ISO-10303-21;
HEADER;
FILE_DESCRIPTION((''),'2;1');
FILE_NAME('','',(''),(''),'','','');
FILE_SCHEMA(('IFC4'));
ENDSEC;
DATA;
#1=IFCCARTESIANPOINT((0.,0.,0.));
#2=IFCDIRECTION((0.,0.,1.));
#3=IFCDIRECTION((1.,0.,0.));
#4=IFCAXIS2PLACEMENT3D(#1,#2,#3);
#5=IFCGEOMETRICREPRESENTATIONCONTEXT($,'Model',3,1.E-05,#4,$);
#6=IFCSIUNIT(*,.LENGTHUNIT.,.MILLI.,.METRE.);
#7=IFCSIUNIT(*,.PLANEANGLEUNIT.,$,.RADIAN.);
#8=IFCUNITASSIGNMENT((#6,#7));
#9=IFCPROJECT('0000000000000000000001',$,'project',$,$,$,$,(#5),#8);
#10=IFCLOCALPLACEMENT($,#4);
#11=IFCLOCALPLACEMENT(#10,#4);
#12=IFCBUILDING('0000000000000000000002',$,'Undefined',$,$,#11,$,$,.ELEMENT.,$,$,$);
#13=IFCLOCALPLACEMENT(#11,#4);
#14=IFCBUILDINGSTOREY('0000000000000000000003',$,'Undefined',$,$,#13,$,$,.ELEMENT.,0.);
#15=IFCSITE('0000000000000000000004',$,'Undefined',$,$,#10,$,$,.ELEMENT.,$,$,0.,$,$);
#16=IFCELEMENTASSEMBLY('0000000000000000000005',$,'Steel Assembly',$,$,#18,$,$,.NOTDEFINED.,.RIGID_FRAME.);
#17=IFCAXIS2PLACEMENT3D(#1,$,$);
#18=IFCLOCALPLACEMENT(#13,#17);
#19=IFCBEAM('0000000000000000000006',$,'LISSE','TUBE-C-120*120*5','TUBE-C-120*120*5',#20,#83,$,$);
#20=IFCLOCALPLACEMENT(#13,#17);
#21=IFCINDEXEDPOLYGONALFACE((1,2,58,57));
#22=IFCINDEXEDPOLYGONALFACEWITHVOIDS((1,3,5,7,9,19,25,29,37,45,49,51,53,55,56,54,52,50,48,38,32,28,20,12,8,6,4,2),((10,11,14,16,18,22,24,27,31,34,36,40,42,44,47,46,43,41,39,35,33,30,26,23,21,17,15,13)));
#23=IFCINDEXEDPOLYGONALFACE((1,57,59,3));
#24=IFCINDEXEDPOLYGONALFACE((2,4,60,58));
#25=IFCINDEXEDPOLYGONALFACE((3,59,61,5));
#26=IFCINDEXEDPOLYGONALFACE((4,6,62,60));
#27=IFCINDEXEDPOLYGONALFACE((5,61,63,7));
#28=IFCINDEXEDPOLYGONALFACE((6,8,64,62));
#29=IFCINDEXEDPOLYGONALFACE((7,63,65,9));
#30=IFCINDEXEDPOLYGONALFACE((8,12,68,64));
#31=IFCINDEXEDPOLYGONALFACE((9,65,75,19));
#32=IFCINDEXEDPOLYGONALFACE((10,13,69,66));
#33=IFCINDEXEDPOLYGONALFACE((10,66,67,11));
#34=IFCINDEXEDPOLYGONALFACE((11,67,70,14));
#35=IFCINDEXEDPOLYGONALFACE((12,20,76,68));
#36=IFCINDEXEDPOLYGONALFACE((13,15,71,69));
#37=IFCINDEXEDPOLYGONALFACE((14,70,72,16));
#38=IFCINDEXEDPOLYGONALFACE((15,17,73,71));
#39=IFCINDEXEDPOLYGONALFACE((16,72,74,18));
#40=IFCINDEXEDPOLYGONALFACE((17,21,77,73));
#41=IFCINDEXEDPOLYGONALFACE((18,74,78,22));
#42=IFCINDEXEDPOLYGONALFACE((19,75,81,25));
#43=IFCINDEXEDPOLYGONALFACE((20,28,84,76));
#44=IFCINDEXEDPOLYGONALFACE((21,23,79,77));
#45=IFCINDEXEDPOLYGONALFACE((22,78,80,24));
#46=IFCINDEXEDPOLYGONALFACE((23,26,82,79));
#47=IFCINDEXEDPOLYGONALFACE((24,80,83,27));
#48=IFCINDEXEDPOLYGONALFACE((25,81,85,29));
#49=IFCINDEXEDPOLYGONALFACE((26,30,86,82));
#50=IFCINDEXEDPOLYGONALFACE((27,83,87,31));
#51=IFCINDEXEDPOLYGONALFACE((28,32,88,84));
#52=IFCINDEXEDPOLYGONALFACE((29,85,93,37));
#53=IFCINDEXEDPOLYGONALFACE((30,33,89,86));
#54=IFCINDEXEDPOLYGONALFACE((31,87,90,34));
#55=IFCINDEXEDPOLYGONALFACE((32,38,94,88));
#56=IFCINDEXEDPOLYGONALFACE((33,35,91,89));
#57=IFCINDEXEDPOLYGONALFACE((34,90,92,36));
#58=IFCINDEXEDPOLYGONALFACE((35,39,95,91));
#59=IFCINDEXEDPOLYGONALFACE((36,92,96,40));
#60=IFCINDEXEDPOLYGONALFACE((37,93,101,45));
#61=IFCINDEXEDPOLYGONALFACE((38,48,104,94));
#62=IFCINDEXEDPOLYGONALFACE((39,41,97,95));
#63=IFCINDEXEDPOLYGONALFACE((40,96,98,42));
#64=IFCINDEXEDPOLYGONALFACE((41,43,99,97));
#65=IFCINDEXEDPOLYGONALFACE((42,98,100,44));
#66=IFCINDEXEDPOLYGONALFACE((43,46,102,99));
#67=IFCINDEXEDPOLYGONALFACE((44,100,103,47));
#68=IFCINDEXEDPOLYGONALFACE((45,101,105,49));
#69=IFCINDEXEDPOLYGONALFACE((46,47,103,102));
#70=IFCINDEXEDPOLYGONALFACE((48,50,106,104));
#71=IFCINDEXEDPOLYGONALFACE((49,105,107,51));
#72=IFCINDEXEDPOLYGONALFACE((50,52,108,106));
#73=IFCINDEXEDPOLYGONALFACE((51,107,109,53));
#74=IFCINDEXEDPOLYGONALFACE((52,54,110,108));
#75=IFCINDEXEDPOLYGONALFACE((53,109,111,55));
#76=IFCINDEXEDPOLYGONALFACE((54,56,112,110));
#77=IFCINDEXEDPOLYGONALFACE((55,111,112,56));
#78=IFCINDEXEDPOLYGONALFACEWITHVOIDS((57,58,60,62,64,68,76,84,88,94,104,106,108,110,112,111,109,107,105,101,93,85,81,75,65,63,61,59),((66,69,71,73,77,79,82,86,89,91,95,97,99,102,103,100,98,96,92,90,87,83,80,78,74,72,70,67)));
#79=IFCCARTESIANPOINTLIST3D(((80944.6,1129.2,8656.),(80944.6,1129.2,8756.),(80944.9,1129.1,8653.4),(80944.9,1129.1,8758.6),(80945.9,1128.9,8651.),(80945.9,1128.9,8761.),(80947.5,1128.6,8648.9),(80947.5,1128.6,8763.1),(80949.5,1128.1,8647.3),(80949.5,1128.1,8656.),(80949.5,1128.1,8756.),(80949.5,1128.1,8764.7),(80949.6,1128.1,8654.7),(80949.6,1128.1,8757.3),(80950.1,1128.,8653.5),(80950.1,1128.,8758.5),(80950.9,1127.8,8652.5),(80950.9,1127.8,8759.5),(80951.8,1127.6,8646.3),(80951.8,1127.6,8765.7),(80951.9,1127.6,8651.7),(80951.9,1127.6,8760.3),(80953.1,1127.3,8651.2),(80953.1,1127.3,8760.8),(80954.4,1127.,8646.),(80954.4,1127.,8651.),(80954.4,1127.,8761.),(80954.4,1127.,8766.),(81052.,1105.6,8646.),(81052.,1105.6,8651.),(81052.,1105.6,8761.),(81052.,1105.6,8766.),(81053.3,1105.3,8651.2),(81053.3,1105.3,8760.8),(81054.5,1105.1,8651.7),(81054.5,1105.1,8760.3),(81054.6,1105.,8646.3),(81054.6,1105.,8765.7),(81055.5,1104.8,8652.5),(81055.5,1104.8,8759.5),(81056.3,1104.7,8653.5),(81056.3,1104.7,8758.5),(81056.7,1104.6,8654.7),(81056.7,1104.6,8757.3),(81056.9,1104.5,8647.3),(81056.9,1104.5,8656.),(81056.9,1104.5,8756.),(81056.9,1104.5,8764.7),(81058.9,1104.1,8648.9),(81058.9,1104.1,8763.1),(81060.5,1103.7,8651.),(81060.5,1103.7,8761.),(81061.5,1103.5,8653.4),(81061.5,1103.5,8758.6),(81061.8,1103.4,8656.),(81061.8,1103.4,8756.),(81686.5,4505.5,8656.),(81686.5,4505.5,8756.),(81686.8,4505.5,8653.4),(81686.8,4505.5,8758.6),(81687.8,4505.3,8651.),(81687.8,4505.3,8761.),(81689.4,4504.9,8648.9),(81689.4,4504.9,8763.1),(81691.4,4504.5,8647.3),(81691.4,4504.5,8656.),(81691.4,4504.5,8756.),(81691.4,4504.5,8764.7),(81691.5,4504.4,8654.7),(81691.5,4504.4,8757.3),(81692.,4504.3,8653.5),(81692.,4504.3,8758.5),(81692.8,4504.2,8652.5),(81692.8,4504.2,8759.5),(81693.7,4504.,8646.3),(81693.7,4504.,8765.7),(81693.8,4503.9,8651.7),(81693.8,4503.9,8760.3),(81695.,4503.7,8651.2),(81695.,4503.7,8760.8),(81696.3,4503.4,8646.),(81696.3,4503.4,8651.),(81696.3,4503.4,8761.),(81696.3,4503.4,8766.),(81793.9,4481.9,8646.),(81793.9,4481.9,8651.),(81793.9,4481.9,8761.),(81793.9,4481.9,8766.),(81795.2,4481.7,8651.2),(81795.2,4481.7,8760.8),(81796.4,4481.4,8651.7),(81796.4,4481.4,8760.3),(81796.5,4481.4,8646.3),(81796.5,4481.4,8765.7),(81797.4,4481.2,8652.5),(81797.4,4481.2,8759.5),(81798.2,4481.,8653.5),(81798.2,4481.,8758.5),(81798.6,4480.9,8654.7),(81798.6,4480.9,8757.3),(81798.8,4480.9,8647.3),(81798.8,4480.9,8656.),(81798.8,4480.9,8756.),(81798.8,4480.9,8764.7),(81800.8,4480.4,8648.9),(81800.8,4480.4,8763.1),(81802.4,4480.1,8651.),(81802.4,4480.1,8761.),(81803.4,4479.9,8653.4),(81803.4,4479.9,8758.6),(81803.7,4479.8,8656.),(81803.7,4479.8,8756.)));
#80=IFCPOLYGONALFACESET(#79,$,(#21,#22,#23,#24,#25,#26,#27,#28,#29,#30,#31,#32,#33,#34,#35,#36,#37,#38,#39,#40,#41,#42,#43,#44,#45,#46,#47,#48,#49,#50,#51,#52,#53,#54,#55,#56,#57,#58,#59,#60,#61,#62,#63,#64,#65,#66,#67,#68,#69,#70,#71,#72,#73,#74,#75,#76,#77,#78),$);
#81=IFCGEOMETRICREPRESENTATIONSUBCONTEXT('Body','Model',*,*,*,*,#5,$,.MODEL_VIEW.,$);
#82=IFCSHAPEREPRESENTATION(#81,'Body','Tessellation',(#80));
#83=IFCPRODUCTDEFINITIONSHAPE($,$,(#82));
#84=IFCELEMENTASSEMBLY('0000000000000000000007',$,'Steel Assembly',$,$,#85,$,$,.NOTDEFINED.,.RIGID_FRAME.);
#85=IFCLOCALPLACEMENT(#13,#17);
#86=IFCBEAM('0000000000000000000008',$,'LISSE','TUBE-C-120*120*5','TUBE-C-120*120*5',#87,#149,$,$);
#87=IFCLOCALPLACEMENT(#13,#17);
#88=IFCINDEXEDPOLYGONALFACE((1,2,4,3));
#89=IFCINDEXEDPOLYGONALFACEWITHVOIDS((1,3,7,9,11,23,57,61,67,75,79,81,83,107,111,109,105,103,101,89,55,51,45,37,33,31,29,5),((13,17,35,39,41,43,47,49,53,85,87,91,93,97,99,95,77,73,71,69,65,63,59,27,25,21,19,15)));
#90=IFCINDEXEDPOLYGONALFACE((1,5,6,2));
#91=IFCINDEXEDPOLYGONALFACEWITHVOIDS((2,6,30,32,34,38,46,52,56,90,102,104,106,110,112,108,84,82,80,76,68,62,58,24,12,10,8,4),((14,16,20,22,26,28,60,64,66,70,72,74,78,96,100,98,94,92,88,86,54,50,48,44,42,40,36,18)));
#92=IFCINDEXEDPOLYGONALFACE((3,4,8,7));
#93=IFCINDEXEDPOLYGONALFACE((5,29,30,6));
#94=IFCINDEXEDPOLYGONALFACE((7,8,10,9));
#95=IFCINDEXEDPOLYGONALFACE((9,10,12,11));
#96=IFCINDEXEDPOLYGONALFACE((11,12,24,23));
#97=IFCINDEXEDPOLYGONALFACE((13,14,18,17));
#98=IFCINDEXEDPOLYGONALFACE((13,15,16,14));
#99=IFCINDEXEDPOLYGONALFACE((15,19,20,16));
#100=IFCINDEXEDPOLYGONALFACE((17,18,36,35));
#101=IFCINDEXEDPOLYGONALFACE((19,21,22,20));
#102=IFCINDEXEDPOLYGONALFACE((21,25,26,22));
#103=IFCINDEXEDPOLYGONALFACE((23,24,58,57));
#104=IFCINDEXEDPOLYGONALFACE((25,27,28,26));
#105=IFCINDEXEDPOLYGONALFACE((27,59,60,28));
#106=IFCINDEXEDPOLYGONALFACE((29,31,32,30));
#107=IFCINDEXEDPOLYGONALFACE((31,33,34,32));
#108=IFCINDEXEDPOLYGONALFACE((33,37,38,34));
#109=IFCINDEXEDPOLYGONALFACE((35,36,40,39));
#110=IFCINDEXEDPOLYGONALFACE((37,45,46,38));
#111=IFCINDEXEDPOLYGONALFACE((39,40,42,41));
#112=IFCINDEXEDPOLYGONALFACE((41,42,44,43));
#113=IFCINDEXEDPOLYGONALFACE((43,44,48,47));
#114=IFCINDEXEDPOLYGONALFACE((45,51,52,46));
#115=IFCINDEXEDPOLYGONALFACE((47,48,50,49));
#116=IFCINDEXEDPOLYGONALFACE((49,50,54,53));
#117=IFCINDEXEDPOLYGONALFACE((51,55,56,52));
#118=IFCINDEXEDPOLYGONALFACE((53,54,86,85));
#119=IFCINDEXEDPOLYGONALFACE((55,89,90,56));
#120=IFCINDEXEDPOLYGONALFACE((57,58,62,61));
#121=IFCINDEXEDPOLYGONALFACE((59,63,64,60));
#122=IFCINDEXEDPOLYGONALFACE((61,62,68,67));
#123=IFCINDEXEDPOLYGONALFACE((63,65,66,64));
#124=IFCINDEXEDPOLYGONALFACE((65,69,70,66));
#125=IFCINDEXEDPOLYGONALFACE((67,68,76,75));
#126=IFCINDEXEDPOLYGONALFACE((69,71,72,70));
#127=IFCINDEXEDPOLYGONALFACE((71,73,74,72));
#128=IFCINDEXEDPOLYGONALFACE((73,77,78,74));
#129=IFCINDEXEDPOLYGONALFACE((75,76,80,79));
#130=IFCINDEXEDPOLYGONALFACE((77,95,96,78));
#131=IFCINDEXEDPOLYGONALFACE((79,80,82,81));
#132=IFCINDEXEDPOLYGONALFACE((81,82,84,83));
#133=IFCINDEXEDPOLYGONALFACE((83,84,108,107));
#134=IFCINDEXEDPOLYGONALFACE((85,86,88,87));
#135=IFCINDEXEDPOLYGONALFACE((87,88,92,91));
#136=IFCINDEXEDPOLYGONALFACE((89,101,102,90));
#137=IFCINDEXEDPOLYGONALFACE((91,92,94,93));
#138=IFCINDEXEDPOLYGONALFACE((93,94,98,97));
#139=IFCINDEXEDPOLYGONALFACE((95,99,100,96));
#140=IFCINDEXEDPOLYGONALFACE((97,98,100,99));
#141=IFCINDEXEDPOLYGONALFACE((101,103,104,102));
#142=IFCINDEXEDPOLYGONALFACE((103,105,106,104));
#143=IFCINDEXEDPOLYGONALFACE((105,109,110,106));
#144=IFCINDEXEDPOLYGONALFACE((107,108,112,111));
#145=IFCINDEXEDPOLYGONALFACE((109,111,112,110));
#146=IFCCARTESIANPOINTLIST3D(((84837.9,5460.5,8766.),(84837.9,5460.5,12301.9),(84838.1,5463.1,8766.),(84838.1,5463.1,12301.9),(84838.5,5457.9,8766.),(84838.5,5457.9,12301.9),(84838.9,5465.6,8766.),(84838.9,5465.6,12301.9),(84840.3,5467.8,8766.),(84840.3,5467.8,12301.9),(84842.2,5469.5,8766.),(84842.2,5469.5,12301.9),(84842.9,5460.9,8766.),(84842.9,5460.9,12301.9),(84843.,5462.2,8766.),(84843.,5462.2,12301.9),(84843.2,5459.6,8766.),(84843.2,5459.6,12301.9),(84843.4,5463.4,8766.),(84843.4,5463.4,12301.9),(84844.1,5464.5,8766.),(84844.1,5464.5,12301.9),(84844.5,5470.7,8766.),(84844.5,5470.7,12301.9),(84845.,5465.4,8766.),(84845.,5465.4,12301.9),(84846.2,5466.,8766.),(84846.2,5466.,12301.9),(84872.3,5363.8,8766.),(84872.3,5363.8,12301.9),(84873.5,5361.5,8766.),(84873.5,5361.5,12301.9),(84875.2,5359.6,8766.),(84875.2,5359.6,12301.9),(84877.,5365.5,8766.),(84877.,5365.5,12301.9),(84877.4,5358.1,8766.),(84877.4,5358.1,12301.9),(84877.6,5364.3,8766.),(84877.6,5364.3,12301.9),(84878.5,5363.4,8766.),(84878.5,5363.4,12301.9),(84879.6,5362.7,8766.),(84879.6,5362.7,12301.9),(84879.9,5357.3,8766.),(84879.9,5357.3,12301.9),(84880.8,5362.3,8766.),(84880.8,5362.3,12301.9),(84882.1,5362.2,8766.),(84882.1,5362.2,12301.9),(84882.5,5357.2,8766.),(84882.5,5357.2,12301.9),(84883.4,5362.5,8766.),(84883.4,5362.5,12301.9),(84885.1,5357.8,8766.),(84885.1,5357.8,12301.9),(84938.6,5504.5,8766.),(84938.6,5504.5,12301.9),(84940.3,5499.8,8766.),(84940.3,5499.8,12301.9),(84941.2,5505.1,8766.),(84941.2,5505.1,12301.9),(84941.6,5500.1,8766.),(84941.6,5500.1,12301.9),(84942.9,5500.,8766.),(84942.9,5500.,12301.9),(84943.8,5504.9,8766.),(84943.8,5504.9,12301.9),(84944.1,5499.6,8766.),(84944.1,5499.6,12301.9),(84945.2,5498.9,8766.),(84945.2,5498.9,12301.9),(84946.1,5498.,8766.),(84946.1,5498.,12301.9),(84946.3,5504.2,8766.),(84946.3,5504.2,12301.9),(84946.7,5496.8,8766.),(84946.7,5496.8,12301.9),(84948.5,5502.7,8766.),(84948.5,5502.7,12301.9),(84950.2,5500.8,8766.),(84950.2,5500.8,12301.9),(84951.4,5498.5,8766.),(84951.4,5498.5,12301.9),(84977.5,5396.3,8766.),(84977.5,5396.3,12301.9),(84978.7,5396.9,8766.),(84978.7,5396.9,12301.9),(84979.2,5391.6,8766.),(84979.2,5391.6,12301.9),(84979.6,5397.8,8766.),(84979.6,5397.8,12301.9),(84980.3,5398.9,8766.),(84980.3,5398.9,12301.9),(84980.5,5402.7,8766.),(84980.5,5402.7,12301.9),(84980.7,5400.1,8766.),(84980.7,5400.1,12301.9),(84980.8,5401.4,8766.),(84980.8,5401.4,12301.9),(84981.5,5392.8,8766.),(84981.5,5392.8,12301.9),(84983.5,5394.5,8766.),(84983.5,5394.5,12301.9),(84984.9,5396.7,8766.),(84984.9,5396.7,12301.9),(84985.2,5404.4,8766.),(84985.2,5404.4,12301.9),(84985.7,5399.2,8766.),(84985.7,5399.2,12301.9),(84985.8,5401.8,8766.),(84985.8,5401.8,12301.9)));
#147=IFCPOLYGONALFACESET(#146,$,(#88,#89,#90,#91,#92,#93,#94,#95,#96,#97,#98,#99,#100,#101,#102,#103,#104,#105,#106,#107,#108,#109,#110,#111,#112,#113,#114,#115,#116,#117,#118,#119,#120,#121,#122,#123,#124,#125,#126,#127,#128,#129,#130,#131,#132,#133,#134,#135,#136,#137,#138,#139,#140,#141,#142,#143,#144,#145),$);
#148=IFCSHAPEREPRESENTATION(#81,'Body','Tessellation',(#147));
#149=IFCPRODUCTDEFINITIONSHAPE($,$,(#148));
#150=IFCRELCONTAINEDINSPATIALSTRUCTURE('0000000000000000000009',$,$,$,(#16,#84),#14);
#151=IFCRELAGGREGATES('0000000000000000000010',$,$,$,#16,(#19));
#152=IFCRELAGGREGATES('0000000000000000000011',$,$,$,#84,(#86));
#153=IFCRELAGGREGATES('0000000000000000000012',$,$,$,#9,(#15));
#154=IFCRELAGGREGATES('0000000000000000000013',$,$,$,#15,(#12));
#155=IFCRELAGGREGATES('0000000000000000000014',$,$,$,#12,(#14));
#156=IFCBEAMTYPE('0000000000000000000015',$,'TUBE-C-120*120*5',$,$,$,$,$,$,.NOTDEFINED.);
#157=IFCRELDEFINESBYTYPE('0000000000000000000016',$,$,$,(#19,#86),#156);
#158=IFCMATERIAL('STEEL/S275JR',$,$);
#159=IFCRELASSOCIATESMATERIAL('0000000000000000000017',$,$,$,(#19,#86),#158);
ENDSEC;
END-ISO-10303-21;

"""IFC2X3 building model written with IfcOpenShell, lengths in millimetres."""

from ifc_helpers import new_model, si_unit, frame, origin_with_axes, origin_2d_with_axis, place, context, subcontext, project, spatial, hollow_rectangle, extrude, material, type_object, element, aggregate, save


model = new_model("IFC2X3")

# Units and contexts
model_context = context("Model", 3, precision=1e-05, world=origin_with_axes())
body_context = subcontext(model_context, "Body", "Model", "MODEL_VIEW")
ifc_project = project(units=[si_unit("LENGTHUNIT", "METRE", prefix="MILLI"), si_unit("PLANEANGLEUNIT", "RADIAN")], contexts=[model_context])

# Site, building, storey
site_placement = place(None, origin_with_axes())
site = spatial("IfcSite", under=ifc_project, at=site_placement, Name="Undefined", CompositionType="ELEMENT", RefElevation=0.0)
building_placement = place(site_placement, origin_with_axes())
building = spatial("IfcBuilding", under=site, at=building_placement, Name="Undefined", CompositionType="ELEMENT")
storey_placement = place(building_placement, origin_with_axes())
storey = spatial("IfcBuildingStorey", under=building, at=storey_placement, Name="Undefined", CompositionType="ELEMENT", Elevation=0.0)

# Element assemblies, beams
ifc_material_1 = material(Name="STEEL/S275JR")
beam_type_1 = type_object("IfcBeamType", Name="TUBE-C-120*120*5", PredefinedType="NOTDEFINED")
assembly_1_placement = place(storey_placement, origin_with_axes())
assembly_1 = element("IfcElementAssembly", 1, at=assembly_1_placement, inside=storey, Name="Steel Assembly", AssemblyPlace="NOTDEFINED", PredefinedType="RIGID_FRAME")
beam_1_placement = place(assembly_1_placement, frame((81745.1, 4492.6, 8706.0), z_axis=(0.976699, -0.214615, 0.0), x_axis=(-0.214615, -0.976699, 0.0)))
beam_1 = element("IfcBeam", 2, at=beam_1_placement, type_object=beam_type_1, material=ifc_material_1, Name="LISSE", Description="TUBE-C-120*120*5", ObjectType="TUBE-C-120*120*5", context=body_context, shape_type="SweptSolid", body=[
    extrude(hollow_rectangle(XDim=120.0, YDim=120.0, WallThickness=5.0, InnerFilletRadius=5.0, OuterFilletRadius=10.0, at=origin_2d_with_axis()), frame((3456.9, 0.0, 0.0), z_axis=(-1.0, 0.0, 0.0), x_axis=(0.0, -1.0, 0.0)), (0.0, 0.0, 1.0), 3456.9),
])
aggregate(assembly_1, [beam_1])
assembly_2_placement = place(storey_placement, origin_with_axes())
assembly_2 = element("IfcElementAssembly", 3, at=assembly_2_placement, inside=storey, Name="Steel Assembly", AssemblyPlace="NOTDEFINED", PredefinedType="RIGID_FRAME")
beam_2_placement = place(assembly_2_placement, frame((84911.9, 5431.1, 12301.9), z_axis=(0.338062, -0.941124, 0.0), x_axis=(0.0, 0.0, -1.0)))
beam_2 = element("IfcBeam", 4, at=beam_2_placement, type_object=beam_type_1, material=ifc_material_1, Name="LISSE", Description="TUBE-C-120*120*5", ObjectType="TUBE-C-120*120*5", context=body_context, shape_type="SweptSolid", body=[
    extrude(hollow_rectangle(XDim=120.0, YDim=120.0, WallThickness=5.0, InnerFilletRadius=5.0, OuterFilletRadius=10.0, at=origin_2d_with_axis()), frame((3535.9, 0.0, 0.0), z_axis=(-1.0, 0.0, 0.0), x_axis=(0.0, -1.0, 0.0)), (0.0, 0.0, 1.0), 3535.9),
])
aggregate(assembly_2, [beam_2])

save(model, "model.ifc")
